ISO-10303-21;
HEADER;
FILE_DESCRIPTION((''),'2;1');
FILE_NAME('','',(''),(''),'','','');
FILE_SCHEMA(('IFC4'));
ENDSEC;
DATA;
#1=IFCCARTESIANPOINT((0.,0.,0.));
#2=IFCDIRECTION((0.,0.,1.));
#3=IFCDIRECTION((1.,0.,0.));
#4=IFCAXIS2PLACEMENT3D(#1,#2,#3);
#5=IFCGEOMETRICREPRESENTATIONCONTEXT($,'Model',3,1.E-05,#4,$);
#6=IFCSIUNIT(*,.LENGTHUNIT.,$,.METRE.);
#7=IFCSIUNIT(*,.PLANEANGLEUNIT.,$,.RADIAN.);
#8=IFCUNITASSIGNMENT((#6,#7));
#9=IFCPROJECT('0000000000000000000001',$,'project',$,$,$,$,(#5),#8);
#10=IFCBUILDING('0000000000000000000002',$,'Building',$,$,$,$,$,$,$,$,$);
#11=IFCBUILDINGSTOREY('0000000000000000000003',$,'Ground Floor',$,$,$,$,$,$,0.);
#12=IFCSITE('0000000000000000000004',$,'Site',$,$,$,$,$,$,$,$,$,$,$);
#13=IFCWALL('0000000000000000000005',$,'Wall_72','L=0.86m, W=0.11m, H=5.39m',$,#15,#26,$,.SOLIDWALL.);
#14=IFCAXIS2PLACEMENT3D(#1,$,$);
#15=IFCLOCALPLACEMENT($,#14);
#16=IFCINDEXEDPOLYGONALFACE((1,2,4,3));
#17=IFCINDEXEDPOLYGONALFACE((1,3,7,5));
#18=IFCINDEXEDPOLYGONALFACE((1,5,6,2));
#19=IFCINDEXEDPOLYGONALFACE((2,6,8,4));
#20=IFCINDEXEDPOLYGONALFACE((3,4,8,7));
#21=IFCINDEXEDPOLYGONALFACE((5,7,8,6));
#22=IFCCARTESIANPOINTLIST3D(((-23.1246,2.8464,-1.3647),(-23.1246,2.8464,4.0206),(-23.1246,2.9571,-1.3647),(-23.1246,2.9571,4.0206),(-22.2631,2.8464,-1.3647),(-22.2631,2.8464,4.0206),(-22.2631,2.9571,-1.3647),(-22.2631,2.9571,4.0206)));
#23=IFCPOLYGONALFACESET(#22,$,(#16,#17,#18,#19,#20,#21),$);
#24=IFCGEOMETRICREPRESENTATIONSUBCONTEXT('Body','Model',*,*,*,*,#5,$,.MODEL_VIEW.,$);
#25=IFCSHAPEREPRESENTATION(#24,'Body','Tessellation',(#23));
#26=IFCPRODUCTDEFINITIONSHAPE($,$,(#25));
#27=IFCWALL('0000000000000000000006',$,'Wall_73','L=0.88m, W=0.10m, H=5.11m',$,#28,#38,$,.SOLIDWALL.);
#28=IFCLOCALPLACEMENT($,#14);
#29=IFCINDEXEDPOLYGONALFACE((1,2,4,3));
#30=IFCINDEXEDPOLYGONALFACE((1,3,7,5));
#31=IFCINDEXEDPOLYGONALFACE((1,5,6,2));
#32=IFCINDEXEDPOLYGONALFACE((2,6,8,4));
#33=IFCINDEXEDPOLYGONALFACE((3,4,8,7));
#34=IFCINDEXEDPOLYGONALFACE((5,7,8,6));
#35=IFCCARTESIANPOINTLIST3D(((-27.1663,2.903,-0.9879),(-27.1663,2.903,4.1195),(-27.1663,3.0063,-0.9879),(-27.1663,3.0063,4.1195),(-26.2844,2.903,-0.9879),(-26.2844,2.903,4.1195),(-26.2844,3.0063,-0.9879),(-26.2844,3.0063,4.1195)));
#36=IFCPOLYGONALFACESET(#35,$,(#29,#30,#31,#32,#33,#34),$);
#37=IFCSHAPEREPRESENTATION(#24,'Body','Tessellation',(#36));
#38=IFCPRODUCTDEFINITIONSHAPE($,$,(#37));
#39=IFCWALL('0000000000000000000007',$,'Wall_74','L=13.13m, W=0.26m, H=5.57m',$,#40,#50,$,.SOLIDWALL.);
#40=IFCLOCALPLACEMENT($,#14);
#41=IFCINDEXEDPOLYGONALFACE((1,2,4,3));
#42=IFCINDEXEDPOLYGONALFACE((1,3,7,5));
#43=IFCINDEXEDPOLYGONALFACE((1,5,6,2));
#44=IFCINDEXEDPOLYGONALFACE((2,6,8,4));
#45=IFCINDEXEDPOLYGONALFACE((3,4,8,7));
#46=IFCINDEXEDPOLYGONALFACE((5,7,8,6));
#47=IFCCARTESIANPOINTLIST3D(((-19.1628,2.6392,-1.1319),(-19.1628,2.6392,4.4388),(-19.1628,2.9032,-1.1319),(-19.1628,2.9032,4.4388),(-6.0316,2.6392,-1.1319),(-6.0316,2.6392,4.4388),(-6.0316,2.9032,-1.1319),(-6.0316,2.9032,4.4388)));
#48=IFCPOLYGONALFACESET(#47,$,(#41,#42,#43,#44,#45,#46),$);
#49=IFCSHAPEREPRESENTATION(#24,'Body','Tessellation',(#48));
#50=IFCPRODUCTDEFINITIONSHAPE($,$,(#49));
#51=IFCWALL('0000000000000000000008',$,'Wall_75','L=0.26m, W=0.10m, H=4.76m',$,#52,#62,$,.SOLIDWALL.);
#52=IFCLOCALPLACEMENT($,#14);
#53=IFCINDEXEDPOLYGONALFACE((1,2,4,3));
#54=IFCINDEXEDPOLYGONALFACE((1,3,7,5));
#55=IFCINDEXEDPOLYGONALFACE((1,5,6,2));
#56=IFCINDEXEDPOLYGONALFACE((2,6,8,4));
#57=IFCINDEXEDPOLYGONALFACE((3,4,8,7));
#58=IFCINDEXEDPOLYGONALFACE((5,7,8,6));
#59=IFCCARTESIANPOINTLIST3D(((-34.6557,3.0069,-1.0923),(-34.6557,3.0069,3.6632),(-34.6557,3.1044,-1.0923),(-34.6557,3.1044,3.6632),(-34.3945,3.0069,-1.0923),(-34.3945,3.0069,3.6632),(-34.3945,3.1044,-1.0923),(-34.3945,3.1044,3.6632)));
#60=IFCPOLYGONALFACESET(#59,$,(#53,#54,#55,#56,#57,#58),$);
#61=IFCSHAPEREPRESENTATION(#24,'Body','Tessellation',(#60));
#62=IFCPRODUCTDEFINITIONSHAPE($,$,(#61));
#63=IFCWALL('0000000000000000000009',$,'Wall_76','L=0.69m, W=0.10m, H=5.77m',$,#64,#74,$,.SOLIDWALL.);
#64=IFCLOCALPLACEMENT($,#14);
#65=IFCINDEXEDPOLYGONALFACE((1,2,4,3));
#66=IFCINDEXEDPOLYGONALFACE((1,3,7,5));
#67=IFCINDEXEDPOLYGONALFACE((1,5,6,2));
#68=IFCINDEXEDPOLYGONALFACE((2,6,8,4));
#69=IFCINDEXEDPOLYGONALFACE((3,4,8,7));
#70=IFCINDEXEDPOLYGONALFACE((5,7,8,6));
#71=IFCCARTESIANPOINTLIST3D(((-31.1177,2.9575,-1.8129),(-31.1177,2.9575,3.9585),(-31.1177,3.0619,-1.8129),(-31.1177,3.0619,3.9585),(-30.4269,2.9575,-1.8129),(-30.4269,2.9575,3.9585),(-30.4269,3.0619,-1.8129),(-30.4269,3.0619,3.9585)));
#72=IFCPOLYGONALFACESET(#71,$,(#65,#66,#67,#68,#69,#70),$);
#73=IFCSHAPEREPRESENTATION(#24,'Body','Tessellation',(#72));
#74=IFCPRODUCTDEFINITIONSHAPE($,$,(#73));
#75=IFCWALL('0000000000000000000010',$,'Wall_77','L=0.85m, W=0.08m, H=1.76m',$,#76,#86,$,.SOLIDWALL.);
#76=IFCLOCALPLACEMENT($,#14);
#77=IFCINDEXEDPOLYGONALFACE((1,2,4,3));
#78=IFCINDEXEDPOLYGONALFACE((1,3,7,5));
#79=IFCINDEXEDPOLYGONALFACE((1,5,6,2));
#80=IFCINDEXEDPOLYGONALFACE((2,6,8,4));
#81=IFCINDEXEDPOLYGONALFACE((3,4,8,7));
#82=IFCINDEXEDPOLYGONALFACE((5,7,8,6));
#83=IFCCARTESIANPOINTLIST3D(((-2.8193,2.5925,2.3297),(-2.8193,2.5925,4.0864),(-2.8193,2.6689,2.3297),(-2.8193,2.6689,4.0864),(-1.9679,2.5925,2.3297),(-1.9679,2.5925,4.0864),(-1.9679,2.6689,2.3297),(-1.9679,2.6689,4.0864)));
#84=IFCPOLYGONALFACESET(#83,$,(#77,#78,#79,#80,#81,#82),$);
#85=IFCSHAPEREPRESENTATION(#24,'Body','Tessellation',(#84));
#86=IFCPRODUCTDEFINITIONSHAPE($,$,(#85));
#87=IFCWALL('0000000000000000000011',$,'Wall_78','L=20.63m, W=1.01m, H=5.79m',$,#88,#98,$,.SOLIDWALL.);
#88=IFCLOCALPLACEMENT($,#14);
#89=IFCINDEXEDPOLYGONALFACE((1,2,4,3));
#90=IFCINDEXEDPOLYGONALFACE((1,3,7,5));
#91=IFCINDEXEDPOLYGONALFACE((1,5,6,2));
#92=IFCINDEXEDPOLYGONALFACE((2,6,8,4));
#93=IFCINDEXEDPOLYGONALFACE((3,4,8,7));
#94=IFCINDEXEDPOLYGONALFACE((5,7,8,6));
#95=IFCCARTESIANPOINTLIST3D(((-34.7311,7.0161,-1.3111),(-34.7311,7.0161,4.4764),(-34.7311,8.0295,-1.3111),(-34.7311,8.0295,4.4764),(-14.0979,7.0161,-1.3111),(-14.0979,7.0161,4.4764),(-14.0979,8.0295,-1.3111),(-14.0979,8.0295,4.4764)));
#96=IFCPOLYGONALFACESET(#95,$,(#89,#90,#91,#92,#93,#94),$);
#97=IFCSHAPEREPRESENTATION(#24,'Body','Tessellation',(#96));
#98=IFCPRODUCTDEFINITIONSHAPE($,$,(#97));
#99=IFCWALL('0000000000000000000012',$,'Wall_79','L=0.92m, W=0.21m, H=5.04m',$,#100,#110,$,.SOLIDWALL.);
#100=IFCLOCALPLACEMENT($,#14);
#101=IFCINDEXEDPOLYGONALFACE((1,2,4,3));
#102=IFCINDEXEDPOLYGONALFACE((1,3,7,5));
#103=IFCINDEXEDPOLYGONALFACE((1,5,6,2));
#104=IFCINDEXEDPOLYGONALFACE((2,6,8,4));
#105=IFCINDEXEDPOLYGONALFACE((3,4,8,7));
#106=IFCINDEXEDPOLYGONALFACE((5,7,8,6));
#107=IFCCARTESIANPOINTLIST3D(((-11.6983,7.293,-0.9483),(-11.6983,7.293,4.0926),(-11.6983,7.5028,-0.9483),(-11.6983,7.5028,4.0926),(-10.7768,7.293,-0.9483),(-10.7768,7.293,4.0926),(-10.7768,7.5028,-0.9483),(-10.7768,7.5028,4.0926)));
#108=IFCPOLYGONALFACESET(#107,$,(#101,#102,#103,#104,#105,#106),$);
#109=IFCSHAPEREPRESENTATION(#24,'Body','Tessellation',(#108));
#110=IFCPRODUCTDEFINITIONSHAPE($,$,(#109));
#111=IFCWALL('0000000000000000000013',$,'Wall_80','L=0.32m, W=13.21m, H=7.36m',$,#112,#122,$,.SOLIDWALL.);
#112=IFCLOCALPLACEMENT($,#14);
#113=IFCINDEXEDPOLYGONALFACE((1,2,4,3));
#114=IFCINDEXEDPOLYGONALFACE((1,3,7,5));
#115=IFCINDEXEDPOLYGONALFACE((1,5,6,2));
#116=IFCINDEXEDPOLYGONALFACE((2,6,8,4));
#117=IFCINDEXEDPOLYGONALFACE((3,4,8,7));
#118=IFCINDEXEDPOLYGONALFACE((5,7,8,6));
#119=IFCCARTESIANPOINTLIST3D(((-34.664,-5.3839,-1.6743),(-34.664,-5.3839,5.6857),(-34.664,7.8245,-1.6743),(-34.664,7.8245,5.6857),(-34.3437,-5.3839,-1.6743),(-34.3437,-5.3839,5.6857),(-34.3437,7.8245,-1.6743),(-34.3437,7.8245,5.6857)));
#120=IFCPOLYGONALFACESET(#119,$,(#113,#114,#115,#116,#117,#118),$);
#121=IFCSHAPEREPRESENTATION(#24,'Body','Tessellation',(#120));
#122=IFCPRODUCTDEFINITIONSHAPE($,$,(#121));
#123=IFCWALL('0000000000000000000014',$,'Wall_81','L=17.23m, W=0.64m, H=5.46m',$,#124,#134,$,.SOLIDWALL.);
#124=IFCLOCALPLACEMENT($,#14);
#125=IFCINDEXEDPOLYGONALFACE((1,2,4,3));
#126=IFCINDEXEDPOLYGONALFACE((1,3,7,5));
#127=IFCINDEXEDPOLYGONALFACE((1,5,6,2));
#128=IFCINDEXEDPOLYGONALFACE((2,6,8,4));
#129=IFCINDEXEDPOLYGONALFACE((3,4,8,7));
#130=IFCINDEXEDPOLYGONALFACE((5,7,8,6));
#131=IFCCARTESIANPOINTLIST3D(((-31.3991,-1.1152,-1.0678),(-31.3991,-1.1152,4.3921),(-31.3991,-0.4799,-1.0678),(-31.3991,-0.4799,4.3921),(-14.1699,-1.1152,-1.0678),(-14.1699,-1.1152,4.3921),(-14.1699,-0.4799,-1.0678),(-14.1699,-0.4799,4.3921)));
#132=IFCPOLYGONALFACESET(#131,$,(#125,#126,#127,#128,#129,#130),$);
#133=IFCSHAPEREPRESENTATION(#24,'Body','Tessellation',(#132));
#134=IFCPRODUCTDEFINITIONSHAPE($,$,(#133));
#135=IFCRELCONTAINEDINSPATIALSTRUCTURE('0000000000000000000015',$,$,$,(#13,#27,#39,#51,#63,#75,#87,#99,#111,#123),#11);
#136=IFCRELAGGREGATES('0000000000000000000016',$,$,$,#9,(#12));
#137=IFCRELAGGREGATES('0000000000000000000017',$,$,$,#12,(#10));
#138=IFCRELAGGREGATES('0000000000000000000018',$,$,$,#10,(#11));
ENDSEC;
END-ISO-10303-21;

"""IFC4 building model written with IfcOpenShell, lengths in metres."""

from ifc_helpers import new_model, si_unit, frame, origin_with_axes, origin_2d, context, subcontext, project, spatial, rectangle, extrude, element, save


model = new_model("IFC4")

# Units and contexts
model_context = context("Model", 3, precision=1e-05, world=origin_with_axes())
body_context = subcontext(model_context, "Body", "Model", "MODEL_VIEW")
ifc_project = project(units=[si_unit("LENGTHUNIT", "METRE"), si_unit("PLANEANGLEUNIT", "RADIAN")], contexts=[model_context])

# Site, building, storey
site = spatial("IfcSite", under=ifc_project, Name="Site")
building = spatial("IfcBuilding", under=site, Name="Building")
storey = spatial("IfcBuildingStorey", under=building, Name="Ground Floor", Elevation=0.0)

# Walls
element("IfcWall", 1, inside=storey, Name="Wall_72", Description="L=0.86m, W=0.11m, H=5.39m", PredefinedType="SOLIDWALL", context=body_context, shape_type="SweptSolid", body=[
    extrude(rectangle(XDim=0.8615, YDim=0.1107, at=origin_2d()), frame((-22.6939, 2.9017, -1.3647), z_axis=(0.0, 0.0, 1.0), x_axis=(1.0, 0.0, 0.0)), (0.0, 0.0, 1.0), 5.3853),
])
element("IfcWall", 2, inside=storey, Name="Wall_73", Description="L=0.88m, W=0.10m, H=5.11m", PredefinedType="SOLIDWALL", context=body_context, shape_type="SweptSolid", body=[
    extrude(rectangle(XDim=0.8819, YDim=0.1033, at=origin_2d()), frame((-26.7254, 2.9547, -0.9879), z_axis=(0.0, 0.0, 1.0), x_axis=(1.0, 0.0, 0.0)), (0.0, 0.0, 1.0), 5.1075),
])
element("IfcWall", 3, inside=storey, Name="Wall_74", Description="L=13.13m, W=0.26m, H=5.57m", PredefinedType="SOLIDWALL", context=body_context, shape_type="SweptSolid", body=[
    extrude(rectangle(XDim=13.1312, YDim=0.264, at=origin_2d()), frame((-12.5972, 2.7712, -1.1319), z_axis=(0.0, 0.0, 1.0), x_axis=(1.0, 0.0, 0.0)), (0.0, 0.0, 1.0), 5.5707),
])
element("IfcWall", 4, inside=storey, Name="Wall_75", Description="L=0.26m, W=0.10m, H=4.76m", PredefinedType="SOLIDWALL", context=body_context, shape_type="SweptSolid", body=[
    extrude(rectangle(XDim=0.2612, YDim=0.0975, at=origin_2d()), frame((-34.5251, 3.0556, -1.0923), z_axis=(0.0, 0.0, 1.0), x_axis=(1.0, 0.0, 0.0)), (0.0, 0.0, 1.0), 4.7555),
])
element("IfcWall", 5, inside=storey, Name="Wall_76", Description="L=0.69m, W=0.10m, H=5.77m", PredefinedType="SOLIDWALL", context=body_context, shape_type="SweptSolid", body=[
    extrude(rectangle(XDim=0.6907, YDim=0.1044, at=origin_2d()), frame((-30.7723, 3.0097, -1.8129), z_axis=(0.0, 0.0, 1.0), x_axis=(1.0, 0.0, 0.0)), (0.0, 0.0, 1.0), 5.7715),
])
element("IfcWall", 6, inside=storey, Name="Wall_77", Description="L=0.85m, W=0.08m, H=1.76m", PredefinedType="SOLIDWALL", context=body_context, shape_type="SweptSolid", body=[
    extrude(rectangle(XDim=0.8514, YDim=0.0764, at=origin_2d()), frame((-2.3936, 2.6307, 2.3297), z_axis=(0.0, 0.0, 1.0), x_axis=(1.0, 0.0, 0.0)), (0.0, 0.0, 1.0), 1.7568),
])
element("IfcWall", 7, inside=storey, Name="Wall_78", Description="L=20.63m, W=1.01m, H=5.79m", PredefinedType="SOLIDWALL", context=body_context, shape_type="SweptSolid", body=[
    extrude(rectangle(XDim=20.6332, YDim=1.0133, at=origin_2d()), frame((-24.4145, 7.5228, -1.3111), z_axis=(0.0, 0.0, 1.0), x_axis=(1.0, 0.0, 0.0)), (0.0, 0.0, 1.0), 5.7875),
])
element("IfcWall", 8, inside=storey, Name="Wall_79", Description="L=0.92m, W=0.21m, H=5.04m", PredefinedType="SOLIDWALL", context=body_context, shape_type="SweptSolid", body=[
    extrude(rectangle(XDim=0.9215, YDim=0.2097, at=origin_2d()), frame((-11.2375, 7.3979, -0.9483), z_axis=(0.0, 0.0, 1.0), x_axis=(1.0, 0.0, 0.0)), (0.0, 0.0, 1.0), 5.0409),
])
element("IfcWall", 9, inside=storey, Name="Wall_80", Description="L=0.32m, W=13.21m, H=7.36m", PredefinedType="SOLIDWALL", context=body_context, shape_type="SweptSolid", body=[
    extrude(rectangle(XDim=0.3203, YDim=13.2084, at=origin_2d()), frame((-34.5038, 1.2203, -1.6743), z_axis=(0.0, 0.0, 1.0), x_axis=(1.0, 0.0, 0.0)), (0.0, 0.0, 1.0), 7.36),
])
element("IfcWall", 10, inside=storey, Name="Wall_81", Description="L=17.23m, W=0.64m, H=5.46m", PredefinedType="SOLIDWALL", context=body_context, shape_type="SweptSolid", body=[
    extrude(rectangle(XDim=17.2292, YDim=0.6353, at=origin_2d()), frame((-22.7845, -0.7975, -1.0678), z_axis=(0.0, 0.0, 1.0), x_axis=(1.0, 0.0, 0.0)), (0.0, 0.0, 1.0), 5.4599),
])

save(model, "model.ifc")
